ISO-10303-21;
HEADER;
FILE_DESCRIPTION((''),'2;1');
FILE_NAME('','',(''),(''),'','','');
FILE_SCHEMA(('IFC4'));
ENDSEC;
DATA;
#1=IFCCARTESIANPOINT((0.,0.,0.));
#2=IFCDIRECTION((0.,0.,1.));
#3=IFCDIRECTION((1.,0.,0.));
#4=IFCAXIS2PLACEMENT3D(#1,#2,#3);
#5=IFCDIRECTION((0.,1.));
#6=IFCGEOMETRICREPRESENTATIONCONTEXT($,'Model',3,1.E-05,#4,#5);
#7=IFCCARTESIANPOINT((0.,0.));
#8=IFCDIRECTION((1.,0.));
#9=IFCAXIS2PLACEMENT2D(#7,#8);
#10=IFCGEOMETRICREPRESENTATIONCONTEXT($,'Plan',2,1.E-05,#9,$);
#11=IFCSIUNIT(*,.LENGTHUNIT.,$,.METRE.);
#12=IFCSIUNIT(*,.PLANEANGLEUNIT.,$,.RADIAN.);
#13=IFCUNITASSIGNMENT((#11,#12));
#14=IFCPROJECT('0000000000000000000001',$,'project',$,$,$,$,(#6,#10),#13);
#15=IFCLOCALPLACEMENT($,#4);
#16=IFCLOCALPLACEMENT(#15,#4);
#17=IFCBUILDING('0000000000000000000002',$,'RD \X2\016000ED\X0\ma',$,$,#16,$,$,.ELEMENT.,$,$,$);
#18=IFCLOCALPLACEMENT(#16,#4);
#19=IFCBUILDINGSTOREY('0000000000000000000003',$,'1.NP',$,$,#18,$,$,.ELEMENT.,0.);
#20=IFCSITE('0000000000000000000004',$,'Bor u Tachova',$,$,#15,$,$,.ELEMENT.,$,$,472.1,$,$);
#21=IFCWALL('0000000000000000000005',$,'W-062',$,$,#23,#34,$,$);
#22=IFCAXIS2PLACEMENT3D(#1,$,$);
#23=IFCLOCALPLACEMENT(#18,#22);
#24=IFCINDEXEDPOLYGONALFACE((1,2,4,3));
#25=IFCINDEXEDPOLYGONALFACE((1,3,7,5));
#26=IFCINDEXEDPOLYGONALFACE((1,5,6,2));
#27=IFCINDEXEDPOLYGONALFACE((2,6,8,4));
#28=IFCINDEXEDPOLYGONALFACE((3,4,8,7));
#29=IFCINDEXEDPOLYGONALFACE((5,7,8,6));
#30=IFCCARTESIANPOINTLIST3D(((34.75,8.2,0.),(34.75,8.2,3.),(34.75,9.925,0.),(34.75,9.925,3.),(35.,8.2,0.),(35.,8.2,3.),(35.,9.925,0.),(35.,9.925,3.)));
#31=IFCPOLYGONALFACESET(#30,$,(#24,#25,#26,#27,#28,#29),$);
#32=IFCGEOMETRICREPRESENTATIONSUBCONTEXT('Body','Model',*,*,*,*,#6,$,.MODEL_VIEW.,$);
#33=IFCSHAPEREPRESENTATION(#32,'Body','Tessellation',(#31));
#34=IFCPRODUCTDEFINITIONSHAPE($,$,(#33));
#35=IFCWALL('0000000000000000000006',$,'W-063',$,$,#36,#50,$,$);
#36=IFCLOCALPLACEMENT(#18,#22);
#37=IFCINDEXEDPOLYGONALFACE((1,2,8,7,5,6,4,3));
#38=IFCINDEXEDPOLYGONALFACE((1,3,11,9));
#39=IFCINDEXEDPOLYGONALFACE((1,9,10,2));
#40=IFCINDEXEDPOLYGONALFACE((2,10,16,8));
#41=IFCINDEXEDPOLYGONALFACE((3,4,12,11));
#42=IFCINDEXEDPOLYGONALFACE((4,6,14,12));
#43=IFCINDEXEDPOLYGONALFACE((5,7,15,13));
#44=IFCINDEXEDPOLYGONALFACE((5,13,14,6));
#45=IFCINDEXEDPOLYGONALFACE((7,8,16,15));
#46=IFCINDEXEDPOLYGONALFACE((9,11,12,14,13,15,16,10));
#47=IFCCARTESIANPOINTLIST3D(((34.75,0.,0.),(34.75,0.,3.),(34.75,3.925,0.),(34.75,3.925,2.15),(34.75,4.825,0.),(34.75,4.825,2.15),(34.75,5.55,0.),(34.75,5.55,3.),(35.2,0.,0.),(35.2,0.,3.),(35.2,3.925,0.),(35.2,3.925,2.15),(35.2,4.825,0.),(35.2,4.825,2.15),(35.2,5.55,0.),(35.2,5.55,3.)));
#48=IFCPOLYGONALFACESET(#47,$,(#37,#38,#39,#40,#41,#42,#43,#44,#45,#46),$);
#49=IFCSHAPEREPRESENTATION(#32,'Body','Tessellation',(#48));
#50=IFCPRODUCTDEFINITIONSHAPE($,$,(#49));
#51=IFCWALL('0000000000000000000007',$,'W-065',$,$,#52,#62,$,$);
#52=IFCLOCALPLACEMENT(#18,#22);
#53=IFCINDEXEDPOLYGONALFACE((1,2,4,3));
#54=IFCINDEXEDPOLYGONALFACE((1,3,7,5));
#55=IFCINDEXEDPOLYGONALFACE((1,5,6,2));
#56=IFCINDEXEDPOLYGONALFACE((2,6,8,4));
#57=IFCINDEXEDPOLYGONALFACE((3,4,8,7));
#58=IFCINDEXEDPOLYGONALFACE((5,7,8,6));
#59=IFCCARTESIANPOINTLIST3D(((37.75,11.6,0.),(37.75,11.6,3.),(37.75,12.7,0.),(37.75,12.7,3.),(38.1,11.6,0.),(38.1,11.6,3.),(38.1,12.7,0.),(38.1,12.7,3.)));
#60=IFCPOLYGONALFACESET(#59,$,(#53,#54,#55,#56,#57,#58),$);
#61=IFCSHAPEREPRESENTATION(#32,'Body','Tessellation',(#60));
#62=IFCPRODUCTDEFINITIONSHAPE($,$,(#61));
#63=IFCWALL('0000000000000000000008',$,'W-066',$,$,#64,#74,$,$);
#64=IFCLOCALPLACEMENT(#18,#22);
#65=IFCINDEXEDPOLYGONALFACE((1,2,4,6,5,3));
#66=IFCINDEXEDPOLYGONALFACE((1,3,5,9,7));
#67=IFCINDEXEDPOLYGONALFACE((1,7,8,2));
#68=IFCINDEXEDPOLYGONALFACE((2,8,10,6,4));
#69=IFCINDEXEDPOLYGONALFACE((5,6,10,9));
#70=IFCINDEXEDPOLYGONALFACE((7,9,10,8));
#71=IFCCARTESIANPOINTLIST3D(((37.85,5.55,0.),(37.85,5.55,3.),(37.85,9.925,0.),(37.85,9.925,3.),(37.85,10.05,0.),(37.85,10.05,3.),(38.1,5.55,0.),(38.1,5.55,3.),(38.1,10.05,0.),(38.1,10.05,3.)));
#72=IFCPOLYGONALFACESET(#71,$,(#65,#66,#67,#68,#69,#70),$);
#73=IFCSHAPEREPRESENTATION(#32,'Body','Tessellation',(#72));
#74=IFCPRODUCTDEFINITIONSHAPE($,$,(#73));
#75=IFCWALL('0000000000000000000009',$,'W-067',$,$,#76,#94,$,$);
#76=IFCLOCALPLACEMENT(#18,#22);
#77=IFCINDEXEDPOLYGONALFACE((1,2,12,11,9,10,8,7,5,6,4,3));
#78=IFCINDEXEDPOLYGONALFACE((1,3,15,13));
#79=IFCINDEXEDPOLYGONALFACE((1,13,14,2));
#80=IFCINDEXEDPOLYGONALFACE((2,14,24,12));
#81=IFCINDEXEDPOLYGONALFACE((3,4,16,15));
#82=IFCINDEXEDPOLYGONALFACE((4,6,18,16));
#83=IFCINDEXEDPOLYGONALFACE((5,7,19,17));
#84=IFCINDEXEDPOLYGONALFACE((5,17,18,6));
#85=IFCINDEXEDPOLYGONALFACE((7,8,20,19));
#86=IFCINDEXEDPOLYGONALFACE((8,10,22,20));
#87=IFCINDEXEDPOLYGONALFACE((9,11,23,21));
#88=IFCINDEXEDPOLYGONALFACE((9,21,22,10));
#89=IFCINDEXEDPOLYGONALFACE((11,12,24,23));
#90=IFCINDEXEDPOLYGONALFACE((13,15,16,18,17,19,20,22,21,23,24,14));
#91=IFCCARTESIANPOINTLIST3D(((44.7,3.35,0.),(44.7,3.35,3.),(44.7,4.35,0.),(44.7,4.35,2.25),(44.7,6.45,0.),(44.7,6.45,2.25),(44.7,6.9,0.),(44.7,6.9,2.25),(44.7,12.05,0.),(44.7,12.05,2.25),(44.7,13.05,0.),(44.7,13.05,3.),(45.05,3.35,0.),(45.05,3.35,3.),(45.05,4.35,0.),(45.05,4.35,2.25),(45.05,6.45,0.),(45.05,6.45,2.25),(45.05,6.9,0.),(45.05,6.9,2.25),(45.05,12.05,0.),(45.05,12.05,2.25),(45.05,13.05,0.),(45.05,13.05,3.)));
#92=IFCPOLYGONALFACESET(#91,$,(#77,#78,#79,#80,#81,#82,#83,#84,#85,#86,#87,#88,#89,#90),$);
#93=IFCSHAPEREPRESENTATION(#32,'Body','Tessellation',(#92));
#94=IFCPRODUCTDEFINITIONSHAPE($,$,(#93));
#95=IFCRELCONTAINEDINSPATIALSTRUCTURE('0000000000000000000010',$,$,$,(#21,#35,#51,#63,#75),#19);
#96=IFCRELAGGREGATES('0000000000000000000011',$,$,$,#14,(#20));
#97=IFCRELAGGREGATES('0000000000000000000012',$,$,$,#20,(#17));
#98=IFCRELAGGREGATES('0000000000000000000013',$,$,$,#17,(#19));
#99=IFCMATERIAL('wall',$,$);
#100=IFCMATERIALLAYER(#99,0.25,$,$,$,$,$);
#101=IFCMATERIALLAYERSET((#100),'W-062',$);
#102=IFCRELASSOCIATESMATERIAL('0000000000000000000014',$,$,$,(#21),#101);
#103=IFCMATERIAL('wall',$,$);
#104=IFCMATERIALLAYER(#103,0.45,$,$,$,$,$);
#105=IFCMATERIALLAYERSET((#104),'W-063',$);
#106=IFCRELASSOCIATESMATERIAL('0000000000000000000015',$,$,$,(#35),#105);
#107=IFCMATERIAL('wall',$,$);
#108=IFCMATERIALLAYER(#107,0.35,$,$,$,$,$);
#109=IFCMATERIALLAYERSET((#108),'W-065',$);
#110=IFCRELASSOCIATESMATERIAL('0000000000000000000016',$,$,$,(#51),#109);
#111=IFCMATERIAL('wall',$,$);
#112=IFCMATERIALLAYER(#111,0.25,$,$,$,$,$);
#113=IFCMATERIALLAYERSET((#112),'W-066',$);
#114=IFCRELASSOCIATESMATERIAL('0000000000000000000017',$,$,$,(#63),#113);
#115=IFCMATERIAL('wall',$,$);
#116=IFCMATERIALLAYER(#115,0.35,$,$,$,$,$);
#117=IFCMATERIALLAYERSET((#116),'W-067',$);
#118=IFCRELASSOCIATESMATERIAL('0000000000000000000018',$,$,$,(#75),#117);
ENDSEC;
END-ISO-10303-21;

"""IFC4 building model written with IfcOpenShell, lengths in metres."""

from ifc_helpers import new_model, si_unit, direction, frame, frame_2d, origin_with_axes, origin_2d_with_axis, place, context, subcontext, project, spatial, line, indexed_curve, rectangle, outline, extrude, material, layer, layer_set, layer_usage, element, save


model = new_model("IFC4")

# Units and contexts
model_context = context("Model", 3, precision=1e-05, world=origin_with_axes(), true_north=direction((0.0, 1.0)))
plan_context = context("Plan", 2, precision=1e-05, world=origin_2d_with_axis())
body_context = subcontext(model_context, "Body", "Model", "MODEL_VIEW")
ifc_project = project(units=[si_unit("LENGTHUNIT", "METRE"), si_unit("PLANEANGLEUNIT", "RADIAN")], contexts=[model_context, plan_context])

# Site, building, storey
site_placement = place(None, origin_with_axes())
site = spatial("IfcSite", under=ifc_project, at=site_placement, Name="Bor u Tachova", CompositionType="ELEMENT", RefElevation=472.1)
building_placement = place(site_placement, origin_with_axes())
building = spatial("IfcBuilding", under=site, at=building_placement, Name="RD Šíma", CompositionType="ELEMENT")
storey_placement = place(building_placement, origin_with_axes())
storey = spatial("IfcBuildingStorey", under=building, at=storey_placement, Name="1.NP", CompositionType="ELEMENT", Elevation=0.0)

# Wall
ifc_material_1 = material(Name="wall")
ifc_layer_1 = layer(ifc_material_1, 0.25)
ifc_layer_set_1 = layer_set([ifc_layer_1], Name="W-062")
ifc_layer_usage_1 = layer_usage(ifc_layer_set_1, "AXIS2", "POSITIVE", -0.125)
wall_1_placement = place(storey_placement, frame((34.875, 8.2, 0.0), z_axis=(0.0, 0.0, 1.0), x_axis=(0.0, 1.0, 0.0)))
element("IfcWall", 1, at=wall_1_placement, inside=storey, material=ifc_layer_usage_1, Name="W-062", context=body_context, shape_type="SweptSolid", body=[
    extrude(outline(indexed_curve([(0.0, -0.125), (0.0, 0.125), (1.725, 0.125), (1.725, -0.125)], segments=[line(1, 2, 3, 4, 1)])), origin_with_axes(), (0.0, 0.0, 1.0), 3.0),
])

# Wall, opening
ifc_material_2 = material(Name="wall")
ifc_layer_2 = layer(ifc_material_2, 0.45)
ifc_layer_set_2 = layer_set([ifc_layer_2], Name="W-063")
ifc_layer_usage_2 = layer_usage(ifc_layer_set_2, "AXIS2", "POSITIVE", -0.225)
wall_2_placement = place(storey_placement, frame((34.975, 0.225, 0.0), z_axis=(0.0, 0.0, 1.0), x_axis=(0.0, 1.0, 0.0)))
wall_2 = element("IfcWall", 2, at=wall_2_placement, inside=storey, material=ifc_layer_usage_2, Name="W-063", context=body_context, shape_type="SweptSolid", body=[
    extrude(outline(indexed_curve([(-0.225, -0.225), (-0.225, 0.225), (0.225, 0.225), (5.325, 0.225), (5.325, -0.225), (5.075, -0.225)], segments=[line(1, 2, 3, 4, 5, 6, 1)])), origin_with_axes(), (0.0, 0.0, 1.0), 3.0),
])
opening_1_placement = place(wall_2_placement, frame((3.7, 0.0, 0.0), z_axis=(0.0, 0.0, 1.0), x_axis=(1.0, 0.0, 0.0)))
element("IfcOpeningElement", 3, at=opening_1_placement, cuts=wall_2, PredefinedType="OPENING", context=body_context, shape_type="SweptSolid", body=[
    extrude(rectangle(XDim=0.9, YDim=0.45, at=frame_2d((0.45, 0.0))), origin_with_axes(), (0.0, 0.0, 1.0), 2.15),
])

# Walls
ifc_material_3 = material(Name="wall")
ifc_layer_3 = layer(ifc_material_3, 0.35)
ifc_layer_set_3 = layer_set([ifc_layer_3], Name="W-065")
ifc_layer_usage_3 = layer_usage(ifc_layer_set_3, "AXIS2", "POSITIVE", -0.175)
wall_3_placement = place(storey_placement, frame((37.925, 11.425, 0.0), z_axis=(0.0, 0.0, 1.0), x_axis=(0.0, 1.0, 0.0)))
element("IfcWall", 4, at=wall_3_placement, inside=storey, material=ifc_layer_usage_3, Name="W-065", context=body_context, shape_type="SweptSolid", body=[
    extrude(outline(indexed_curve([(0.175, -0.175), (0.175, 0.175), (1.275, 0.175), (1.275, -0.175)], segments=[line(1, 2, 3, 4, 1)])), origin_with_axes(), (0.0, 0.0, 1.0), 3.0),
])
ifc_material_4 = material(Name="wall")
ifc_layer_4 = layer(ifc_material_4, 0.25)
ifc_layer_set_4 = layer_set([ifc_layer_4], Name="W-066")
ifc_layer_usage_4 = layer_usage(ifc_layer_set_4, "AXIS2", "POSITIVE", -0.125)
wall_4_placement = place(storey_placement, frame((37.975, 5.55, 0.0), z_axis=(0.0, 0.0, 1.0), x_axis=(0.0, 1.0, 0.0)))
element("IfcWall", 5, at=wall_4_placement, inside=storey, material=ifc_layer_usage_4, Name="W-066", context=body_context, shape_type="SweptSolid", body=[
    extrude(outline(indexed_curve([(0.0, -0.125), (0.0, 0.125), (4.375, 0.125), (4.5, 0.125), (4.5, -0.125)], segments=[line(1, 2, 3, 4, 5, 1)])), origin_with_axes(), (0.0, 0.0, 1.0), 3.0),
])

# Wall, openings
ifc_material_5 = material(Name="wall")
ifc_layer_5 = layer(ifc_material_5, 0.35)
ifc_layer_set_5 = layer_set([ifc_layer_5], Name="W-067")
ifc_layer_usage_5 = layer_usage(ifc_layer_set_5, "AXIS2", "POSITIVE", -0.175)
wall_5_placement = place(storey_placement, frame((44.875, 3.525, 0.0), z_axis=(0.0, 0.0, 1.0), x_axis=(0.0, 1.0, 0.0)))
wall_5 = element("IfcWall", 6, at=wall_5_placement, inside=storey, material=ifc_layer_usage_5, Name="W-067", context=body_context, shape_type="SweptSolid", body=[
    extrude(outline(indexed_curve([(-0.175, -0.175), (-0.175, 0.175), (0.175, 0.175), (9.175, 0.175), (9.525, 0.175), (9.525, -0.175)], segments=[line(1, 2, 3, 4, 5, 6, 1)])), origin_with_axes(), (0.0, 0.0, 1.0), 3.0),
])
opening_2_placement = place(wall_5_placement, frame((0.825, 0.0, 0.0), z_axis=(0.0, 0.0, 1.0), x_axis=(1.0, 0.0, 0.0)))
element("IfcOpeningElement", 7, at=opening_2_placement, cuts=wall_5, PredefinedType="OPENING", context=body_context, shape_type="SweptSolid", body=[
    extrude(rectangle(XDim=2.1, YDim=0.35, at=frame_2d((1.05, 0.0))), origin_with_axes(), (0.0, 0.0, 1.0), 2.25),
])
opening_3_placement = place(wall_5_placement, frame((3.375, 0.0, 0.0), z_axis=(0.0, 0.0, 1.0), x_axis=(1.0, 0.0, 0.0)))
element("IfcOpeningElement", 8, at=opening_3_placement, cuts=wall_5, PredefinedType="OPENING", context=body_context, shape_type="SweptSolid", body=[
    extrude(rectangle(XDim=5.15, YDim=0.35, at=frame_2d((2.575, 0.0))), origin_with_axes(), (0.0, 0.0, 1.0), 2.25),
])

save(model, "model.ifc")
